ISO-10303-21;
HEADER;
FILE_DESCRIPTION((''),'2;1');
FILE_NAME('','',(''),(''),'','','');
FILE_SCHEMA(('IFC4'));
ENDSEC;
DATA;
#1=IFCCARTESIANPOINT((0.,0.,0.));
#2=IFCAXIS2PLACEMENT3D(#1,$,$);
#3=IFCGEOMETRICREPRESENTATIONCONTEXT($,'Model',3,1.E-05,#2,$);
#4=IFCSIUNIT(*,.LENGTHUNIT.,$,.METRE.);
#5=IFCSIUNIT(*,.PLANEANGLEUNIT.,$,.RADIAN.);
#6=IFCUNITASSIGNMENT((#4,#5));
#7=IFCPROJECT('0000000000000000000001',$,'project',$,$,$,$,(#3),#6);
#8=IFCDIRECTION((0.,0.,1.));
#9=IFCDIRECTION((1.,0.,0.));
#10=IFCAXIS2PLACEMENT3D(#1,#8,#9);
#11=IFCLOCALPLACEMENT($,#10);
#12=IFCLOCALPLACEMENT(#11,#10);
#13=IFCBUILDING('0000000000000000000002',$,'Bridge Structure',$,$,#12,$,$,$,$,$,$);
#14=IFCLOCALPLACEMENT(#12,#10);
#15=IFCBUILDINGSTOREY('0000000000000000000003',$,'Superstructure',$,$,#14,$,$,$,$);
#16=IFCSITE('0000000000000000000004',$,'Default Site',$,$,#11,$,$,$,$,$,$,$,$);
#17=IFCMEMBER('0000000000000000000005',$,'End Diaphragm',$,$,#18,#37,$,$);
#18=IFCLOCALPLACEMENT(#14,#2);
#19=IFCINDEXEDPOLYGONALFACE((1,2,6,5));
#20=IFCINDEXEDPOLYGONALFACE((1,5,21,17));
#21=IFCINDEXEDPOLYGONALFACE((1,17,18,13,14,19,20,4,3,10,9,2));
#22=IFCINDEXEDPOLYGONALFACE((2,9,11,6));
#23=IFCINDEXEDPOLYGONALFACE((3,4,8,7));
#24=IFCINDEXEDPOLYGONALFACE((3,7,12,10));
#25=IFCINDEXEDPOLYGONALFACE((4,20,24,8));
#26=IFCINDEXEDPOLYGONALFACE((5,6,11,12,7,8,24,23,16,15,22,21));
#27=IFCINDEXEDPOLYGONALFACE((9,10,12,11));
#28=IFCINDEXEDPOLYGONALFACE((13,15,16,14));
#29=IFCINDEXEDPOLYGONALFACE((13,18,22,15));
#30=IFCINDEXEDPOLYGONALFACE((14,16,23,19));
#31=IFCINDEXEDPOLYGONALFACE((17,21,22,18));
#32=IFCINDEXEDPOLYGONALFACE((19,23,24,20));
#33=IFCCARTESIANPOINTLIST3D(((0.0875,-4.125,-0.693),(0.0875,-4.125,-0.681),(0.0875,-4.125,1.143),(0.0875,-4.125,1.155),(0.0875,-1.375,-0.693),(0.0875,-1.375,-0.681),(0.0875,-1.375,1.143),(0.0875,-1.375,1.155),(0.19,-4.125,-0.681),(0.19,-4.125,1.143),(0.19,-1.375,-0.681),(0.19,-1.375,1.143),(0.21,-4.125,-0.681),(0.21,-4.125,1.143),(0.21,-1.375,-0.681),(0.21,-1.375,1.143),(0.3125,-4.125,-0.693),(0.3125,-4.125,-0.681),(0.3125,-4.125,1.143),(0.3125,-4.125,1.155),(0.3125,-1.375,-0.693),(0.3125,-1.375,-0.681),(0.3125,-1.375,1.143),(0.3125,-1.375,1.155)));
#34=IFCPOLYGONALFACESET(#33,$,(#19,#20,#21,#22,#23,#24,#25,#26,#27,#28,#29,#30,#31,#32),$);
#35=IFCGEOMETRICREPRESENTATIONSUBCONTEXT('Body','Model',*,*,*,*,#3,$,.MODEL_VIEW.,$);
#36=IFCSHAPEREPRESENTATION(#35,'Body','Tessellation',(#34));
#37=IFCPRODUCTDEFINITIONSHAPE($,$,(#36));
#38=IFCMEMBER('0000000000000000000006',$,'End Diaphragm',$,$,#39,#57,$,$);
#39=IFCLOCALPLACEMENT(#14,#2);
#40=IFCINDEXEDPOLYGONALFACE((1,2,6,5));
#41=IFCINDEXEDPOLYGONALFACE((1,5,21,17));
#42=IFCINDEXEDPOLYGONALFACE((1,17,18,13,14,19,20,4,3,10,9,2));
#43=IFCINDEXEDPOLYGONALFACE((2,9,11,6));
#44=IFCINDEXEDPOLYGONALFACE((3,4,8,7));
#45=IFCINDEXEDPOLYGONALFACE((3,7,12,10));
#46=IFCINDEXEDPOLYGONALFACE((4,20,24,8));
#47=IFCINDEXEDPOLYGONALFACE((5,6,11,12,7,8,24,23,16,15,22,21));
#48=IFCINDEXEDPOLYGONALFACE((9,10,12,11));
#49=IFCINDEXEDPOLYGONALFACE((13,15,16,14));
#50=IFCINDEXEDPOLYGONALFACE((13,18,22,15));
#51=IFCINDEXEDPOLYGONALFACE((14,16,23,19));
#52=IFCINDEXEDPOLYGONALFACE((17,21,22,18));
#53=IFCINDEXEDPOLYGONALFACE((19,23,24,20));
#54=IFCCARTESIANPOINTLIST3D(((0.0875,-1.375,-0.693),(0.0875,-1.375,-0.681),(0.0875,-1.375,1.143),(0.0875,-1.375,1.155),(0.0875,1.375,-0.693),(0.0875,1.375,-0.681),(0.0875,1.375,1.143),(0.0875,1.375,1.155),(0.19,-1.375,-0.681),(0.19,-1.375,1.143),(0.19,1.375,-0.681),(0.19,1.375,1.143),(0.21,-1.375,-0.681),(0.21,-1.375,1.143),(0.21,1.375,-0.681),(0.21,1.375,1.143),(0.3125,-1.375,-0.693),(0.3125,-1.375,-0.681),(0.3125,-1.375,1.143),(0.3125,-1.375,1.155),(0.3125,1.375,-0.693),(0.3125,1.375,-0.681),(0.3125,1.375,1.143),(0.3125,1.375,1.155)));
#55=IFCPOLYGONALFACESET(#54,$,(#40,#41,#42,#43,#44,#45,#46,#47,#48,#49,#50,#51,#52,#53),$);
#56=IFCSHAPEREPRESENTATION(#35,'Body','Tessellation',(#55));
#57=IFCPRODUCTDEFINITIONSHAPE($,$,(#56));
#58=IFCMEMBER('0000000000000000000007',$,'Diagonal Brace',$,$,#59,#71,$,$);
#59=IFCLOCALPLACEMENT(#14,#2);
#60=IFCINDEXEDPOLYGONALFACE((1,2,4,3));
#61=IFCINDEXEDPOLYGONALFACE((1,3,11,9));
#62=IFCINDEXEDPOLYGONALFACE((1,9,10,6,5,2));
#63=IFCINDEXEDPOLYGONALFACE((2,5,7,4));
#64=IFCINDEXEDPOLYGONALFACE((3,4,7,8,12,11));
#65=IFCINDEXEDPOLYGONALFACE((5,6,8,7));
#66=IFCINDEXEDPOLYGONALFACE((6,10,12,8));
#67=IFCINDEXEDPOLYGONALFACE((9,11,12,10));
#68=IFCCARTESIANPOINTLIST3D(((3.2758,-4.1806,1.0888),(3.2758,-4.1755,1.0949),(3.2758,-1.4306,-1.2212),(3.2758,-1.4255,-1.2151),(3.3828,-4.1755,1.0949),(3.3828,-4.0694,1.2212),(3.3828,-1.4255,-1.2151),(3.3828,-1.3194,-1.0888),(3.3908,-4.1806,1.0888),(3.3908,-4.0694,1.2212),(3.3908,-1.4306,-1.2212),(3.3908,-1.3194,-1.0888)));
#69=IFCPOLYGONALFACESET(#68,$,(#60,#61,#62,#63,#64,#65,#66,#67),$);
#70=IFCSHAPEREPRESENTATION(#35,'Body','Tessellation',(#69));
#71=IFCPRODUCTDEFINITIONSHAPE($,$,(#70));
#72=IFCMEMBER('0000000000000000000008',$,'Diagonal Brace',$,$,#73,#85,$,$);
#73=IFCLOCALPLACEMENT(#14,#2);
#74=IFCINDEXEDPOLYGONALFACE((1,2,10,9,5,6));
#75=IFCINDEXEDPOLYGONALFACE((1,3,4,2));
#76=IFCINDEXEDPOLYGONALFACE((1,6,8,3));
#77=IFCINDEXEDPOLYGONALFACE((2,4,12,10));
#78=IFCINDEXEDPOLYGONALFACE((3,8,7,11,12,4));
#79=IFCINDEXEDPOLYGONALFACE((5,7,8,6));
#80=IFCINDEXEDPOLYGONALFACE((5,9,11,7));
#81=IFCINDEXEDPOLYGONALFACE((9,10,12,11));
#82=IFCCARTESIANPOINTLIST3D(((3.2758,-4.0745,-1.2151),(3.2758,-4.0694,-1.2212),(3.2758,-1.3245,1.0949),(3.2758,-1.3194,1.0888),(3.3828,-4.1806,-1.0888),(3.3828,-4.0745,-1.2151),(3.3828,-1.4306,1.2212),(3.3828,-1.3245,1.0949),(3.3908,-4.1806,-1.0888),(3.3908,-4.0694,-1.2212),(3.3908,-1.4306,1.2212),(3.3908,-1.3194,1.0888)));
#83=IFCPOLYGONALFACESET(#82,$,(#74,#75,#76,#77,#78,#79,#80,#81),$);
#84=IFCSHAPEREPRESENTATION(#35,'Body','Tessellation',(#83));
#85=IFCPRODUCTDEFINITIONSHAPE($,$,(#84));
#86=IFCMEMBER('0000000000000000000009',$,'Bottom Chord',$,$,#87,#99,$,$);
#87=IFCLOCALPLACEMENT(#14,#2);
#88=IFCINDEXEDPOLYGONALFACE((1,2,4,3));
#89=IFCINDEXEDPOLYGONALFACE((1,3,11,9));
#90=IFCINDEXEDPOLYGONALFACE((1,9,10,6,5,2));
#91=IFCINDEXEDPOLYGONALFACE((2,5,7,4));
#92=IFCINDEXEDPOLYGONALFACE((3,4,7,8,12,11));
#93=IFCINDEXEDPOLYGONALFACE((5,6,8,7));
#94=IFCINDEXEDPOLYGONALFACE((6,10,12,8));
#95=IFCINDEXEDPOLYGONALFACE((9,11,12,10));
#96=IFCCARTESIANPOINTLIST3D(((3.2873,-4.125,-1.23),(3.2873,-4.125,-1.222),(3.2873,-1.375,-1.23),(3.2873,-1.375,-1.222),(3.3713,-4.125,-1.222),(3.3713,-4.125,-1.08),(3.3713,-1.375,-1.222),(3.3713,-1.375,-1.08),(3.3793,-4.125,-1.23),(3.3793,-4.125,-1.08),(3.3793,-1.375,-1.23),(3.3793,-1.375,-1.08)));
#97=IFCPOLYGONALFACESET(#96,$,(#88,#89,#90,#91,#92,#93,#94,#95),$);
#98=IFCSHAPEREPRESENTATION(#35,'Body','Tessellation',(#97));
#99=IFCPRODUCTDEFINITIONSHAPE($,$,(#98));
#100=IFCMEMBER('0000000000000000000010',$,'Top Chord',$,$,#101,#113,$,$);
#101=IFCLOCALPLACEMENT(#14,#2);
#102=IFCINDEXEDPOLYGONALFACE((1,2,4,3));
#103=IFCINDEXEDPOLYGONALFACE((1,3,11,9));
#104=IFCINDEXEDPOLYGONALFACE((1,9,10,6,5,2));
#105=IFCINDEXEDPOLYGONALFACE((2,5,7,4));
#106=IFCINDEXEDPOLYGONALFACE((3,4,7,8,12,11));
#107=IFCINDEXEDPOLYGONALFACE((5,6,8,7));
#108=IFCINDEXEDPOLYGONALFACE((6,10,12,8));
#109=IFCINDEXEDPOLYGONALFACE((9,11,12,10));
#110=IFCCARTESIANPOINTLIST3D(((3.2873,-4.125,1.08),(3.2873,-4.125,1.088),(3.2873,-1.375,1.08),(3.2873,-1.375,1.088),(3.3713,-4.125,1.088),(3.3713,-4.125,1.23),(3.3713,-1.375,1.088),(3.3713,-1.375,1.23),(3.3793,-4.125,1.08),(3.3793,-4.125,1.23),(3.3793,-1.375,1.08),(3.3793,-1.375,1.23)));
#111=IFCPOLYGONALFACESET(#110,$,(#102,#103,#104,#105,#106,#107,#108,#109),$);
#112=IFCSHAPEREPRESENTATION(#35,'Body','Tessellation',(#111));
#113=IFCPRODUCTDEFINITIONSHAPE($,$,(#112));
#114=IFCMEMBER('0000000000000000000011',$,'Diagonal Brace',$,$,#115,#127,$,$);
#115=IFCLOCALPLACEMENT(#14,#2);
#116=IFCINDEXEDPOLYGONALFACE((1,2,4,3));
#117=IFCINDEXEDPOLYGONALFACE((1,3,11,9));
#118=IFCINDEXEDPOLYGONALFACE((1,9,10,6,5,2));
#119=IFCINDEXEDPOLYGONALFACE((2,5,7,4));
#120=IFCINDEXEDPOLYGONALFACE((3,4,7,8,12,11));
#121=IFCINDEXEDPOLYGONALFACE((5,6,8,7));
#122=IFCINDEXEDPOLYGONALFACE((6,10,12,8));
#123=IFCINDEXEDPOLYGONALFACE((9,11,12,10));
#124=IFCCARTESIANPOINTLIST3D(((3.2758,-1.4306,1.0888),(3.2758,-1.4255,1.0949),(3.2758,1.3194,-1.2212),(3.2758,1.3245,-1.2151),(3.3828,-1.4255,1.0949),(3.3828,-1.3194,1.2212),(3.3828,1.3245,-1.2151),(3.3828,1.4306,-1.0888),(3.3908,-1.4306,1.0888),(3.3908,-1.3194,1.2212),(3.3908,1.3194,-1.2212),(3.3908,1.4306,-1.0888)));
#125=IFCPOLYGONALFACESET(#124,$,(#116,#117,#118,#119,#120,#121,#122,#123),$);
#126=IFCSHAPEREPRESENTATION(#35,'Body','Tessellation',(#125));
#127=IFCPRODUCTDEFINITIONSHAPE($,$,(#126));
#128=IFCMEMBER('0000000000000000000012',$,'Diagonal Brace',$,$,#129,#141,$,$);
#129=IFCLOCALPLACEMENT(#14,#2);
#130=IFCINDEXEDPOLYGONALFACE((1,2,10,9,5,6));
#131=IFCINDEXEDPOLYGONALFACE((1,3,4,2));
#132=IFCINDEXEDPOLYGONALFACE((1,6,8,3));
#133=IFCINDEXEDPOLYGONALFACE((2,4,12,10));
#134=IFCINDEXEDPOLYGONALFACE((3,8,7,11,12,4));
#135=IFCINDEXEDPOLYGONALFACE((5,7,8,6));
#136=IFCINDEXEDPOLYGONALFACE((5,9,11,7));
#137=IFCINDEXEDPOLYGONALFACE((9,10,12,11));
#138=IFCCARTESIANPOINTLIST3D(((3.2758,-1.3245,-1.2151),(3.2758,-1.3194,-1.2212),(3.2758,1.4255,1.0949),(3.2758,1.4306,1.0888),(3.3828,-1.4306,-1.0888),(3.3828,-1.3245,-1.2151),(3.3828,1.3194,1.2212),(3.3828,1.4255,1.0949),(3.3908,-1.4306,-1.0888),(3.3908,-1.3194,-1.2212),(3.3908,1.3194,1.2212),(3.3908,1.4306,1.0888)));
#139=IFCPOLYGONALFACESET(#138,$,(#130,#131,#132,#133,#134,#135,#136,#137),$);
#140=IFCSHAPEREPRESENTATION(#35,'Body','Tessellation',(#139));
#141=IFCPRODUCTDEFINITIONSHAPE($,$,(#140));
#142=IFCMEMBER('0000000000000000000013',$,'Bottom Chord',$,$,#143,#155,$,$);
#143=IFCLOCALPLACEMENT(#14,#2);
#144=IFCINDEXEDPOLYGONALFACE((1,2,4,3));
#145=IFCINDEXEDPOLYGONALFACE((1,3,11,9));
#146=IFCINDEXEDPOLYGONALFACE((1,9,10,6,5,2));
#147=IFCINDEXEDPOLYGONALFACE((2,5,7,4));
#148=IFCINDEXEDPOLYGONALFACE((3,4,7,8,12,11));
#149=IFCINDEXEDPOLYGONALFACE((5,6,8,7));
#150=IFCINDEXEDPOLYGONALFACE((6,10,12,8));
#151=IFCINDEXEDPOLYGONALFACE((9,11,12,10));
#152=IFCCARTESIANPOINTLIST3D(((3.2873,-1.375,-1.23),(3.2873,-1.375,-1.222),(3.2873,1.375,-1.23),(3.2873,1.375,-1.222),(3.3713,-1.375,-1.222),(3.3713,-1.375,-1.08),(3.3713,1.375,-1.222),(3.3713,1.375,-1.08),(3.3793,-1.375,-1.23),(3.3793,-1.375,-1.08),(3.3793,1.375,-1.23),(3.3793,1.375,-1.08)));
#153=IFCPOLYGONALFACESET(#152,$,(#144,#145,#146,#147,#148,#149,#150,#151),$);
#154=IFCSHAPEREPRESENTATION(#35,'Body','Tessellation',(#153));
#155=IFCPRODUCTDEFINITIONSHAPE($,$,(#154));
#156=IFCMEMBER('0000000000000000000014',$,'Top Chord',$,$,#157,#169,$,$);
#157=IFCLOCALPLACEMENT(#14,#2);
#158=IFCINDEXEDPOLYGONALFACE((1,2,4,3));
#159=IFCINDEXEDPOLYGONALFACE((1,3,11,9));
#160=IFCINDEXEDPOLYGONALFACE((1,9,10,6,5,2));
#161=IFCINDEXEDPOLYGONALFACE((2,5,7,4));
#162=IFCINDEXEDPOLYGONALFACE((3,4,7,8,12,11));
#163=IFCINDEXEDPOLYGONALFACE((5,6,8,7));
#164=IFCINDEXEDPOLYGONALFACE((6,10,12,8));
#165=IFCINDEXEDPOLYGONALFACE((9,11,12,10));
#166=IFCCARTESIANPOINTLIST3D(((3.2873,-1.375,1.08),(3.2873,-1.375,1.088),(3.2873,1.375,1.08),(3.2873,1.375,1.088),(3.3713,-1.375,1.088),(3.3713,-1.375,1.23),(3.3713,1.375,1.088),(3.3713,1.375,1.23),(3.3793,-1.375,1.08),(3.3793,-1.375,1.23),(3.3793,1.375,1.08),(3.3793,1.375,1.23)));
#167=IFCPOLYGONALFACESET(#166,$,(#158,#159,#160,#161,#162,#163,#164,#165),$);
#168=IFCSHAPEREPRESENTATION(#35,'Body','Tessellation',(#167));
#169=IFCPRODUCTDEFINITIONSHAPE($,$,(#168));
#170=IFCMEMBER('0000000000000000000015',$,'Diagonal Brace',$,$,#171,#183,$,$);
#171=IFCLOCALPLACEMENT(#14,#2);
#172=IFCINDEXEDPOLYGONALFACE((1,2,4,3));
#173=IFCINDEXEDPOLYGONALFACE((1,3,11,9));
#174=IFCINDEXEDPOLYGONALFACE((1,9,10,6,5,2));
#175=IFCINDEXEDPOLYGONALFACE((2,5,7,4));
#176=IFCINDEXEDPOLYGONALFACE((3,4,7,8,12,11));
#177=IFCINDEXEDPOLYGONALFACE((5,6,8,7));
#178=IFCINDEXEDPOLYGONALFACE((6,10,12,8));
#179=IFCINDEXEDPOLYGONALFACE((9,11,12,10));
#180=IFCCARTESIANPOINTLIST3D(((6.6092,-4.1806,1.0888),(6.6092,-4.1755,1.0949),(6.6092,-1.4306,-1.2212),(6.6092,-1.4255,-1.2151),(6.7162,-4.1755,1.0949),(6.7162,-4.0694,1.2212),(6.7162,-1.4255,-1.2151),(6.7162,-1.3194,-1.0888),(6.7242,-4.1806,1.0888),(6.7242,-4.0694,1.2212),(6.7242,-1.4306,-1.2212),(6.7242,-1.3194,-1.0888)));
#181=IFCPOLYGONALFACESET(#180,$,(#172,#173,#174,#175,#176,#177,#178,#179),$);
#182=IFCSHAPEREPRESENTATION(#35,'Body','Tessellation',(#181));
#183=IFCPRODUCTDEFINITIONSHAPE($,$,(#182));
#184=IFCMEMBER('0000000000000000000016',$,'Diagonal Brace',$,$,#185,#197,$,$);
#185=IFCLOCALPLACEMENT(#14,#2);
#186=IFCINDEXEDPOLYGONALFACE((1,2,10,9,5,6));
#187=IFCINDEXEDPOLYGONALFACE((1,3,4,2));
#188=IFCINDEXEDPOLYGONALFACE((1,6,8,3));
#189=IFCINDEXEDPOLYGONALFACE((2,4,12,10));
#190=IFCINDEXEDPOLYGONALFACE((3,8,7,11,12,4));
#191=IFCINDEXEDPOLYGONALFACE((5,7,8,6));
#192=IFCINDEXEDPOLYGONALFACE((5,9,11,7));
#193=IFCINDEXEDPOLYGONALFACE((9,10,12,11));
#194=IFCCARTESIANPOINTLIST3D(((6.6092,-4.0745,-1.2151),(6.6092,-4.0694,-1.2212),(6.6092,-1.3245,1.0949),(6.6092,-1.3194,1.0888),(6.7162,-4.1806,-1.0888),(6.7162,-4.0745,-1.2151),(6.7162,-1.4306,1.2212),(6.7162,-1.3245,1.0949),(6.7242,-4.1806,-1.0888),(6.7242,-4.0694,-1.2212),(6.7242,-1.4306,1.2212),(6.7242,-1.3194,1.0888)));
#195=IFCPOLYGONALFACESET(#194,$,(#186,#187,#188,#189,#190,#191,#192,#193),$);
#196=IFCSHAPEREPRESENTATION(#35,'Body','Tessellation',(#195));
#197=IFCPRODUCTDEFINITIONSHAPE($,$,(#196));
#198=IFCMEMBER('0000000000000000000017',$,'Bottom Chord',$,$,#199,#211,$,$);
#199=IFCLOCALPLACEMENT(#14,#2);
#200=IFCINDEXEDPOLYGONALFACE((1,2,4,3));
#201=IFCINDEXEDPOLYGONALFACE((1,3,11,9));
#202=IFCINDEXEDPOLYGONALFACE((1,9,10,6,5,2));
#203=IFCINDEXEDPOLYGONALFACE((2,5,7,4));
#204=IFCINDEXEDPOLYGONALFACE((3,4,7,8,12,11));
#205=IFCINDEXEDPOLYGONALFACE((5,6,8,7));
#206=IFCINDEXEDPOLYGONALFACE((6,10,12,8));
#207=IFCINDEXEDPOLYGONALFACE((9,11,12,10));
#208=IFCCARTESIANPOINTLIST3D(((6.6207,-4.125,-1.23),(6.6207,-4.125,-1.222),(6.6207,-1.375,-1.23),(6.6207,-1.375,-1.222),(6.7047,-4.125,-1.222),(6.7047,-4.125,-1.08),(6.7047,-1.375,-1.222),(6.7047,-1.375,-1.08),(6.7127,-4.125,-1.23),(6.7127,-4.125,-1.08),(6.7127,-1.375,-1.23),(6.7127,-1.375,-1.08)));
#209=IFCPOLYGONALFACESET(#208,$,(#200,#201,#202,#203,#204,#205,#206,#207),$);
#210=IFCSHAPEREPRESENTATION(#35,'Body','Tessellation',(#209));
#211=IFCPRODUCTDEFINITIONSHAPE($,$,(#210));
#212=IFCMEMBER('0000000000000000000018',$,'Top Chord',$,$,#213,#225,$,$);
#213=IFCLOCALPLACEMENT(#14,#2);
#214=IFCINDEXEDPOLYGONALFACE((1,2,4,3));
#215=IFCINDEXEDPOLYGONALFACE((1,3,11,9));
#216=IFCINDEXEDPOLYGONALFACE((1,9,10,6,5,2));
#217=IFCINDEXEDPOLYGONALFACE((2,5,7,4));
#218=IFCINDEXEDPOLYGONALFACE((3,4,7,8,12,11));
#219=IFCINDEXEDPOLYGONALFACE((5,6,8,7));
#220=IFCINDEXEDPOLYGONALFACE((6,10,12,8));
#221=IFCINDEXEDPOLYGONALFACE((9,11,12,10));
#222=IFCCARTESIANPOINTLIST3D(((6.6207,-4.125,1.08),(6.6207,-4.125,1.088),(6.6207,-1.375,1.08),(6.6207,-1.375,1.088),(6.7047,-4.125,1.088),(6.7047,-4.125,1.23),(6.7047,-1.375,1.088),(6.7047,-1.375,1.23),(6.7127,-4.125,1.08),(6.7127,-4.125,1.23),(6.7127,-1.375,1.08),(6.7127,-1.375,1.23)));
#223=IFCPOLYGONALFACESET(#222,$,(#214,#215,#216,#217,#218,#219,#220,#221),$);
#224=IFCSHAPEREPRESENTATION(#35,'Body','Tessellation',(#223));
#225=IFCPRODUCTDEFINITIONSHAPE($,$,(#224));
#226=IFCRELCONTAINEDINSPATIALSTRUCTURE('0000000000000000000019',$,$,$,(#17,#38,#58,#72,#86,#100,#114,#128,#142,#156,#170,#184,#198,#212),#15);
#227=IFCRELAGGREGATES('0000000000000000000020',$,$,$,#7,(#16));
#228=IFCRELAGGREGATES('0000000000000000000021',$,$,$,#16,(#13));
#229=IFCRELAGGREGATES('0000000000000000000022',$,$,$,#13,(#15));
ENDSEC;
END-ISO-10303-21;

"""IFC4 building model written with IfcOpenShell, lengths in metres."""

from ifc_helpers import new_model, si_unit, frame, origin, origin_with_axes, origin_2d_with_axis, place, context, subcontext, project, spatial, i_section, l_section, extrude, element, save


model = new_model("IFC4")

# Units and contexts
model_context = context("Model", 3, precision=1e-05, world=origin())
body_context = subcontext(model_context, "Body", "Model", "MODEL_VIEW")
ifc_project = project(units=[si_unit("LENGTHUNIT", "METRE"), si_unit("PLANEANGLEUNIT", "RADIAN")], contexts=[model_context])

# Site, building, storey
site_placement = place(None, origin_with_axes())
site = spatial("IfcSite", under=ifc_project, at=site_placement, Name="Default Site")
building_placement = place(site_placement, origin_with_axes())
building = spatial("IfcBuilding", under=site, at=building_placement, Name="Bridge Structure")
storey_placement = place(building_placement, origin_with_axes())
storey = spatial("IfcBuildingStorey", under=building, at=storey_placement, Name="Superstructure")

# Members
for number, where, z_axis, x_axis, name in (
    (1, (0.2, -4.125, 0.231), (0.0, 1.0, 0.0), (-1.0, 0.0, 0.0), "End Diaphragm"),
    (2, (0.2, -1.375, 0.231), (0.0, 1.0, 0.0), (-1.0, 0.0, 0.0), "End Diaphragm"),
):
    element("IfcMember", number, at=place(storey_placement, frame(where, z_axis=z_axis, x_axis=x_axis)), inside=storey, Name=name, context=body_context, shape_type="SweptSolid", body=[
        extrude(i_section(OverallWidth=0.225, OverallDepth=1.848, WebThickness=0.02, FlangeThickness=0.012, at=origin_2d_with_axis()), origin_with_axes(), (0.0, 0.0, 1.0), 2.75),
    ])
for number, where, z_axis, x_axis, name in (
    (3, (3.3333, -4.125, 1.155), (0.0, 0.765705, -0.643192), (-1.0, 0.0, 0.0), "Diagonal Brace"),
    (4, (3.3333, -4.125, -1.155), (0.0, 0.765705, 0.643192), (-1.0, 0.0, 0.0), "Diagonal Brace"),
):
    element("IfcMember", number, at=place(storey_placement, frame(where, z_axis=z_axis, x_axis=x_axis)), inside=storey, Name=name, context=body_context, shape_type="SweptSolid", body=[
        extrude(l_section(Depth=0.173, Width=0.115, Thickness=0.008, at=origin_2d_with_axis()), origin_with_axes(), (0.0, 0.0, 1.0), 3.5915),
    ])
for number, where, z_axis, x_axis, name in (
    (5, (3.3333, -4.125, -1.155), (0.0, 1.0, 0.0), (-1.0, 0.0, 0.0), "Bottom Chord"),
    (6, (3.3333, -4.125, 1.155), (0.0, 1.0, 0.0), (-1.0, 0.0, 0.0), "Top Chord"),
):
    element("IfcMember", number, at=place(storey_placement, frame(where, z_axis=z_axis, x_axis=x_axis)), inside=storey, Name=name, context=body_context, shape_type="SweptSolid", body=[
        extrude(l_section(Depth=0.15, Width=0.092, Thickness=0.008, at=origin_2d_with_axis()), origin_with_axes(), (0.0, 0.0, 1.0), 2.75),
    ])
for number, where, z_axis, x_axis, name in (
    (7, (3.3333, -1.375, 1.155), (0.0, 0.765705, -0.643192), (-1.0, 0.0, 0.0), "Diagonal Brace"),
    (8, (3.3333, -1.375, -1.155), (0.0, 0.765705, 0.643192), (-1.0, 0.0, 0.0), "Diagonal Brace"),
):
    element("IfcMember", number, at=place(storey_placement, frame(where, z_axis=z_axis, x_axis=x_axis)), inside=storey, Name=name, context=body_context, shape_type="SweptSolid", body=[
        extrude(l_section(Depth=0.173, Width=0.115, Thickness=0.008, at=origin_2d_with_axis()), origin_with_axes(), (0.0, 0.0, 1.0), 3.5915),
    ])
for number, where, z_axis, x_axis, name in (
    (9, (3.3333, -1.375, -1.155), (0.0, 1.0, 0.0), (-1.0, 0.0, 0.0), "Bottom Chord"),
    (10, (3.3333, -1.375, 1.155), (0.0, 1.0, 0.0), (-1.0, 0.0, 0.0), "Top Chord"),
):
    element("IfcMember", number, at=place(storey_placement, frame(where, z_axis=z_axis, x_axis=x_axis)), inside=storey, Name=name, context=body_context, shape_type="SweptSolid", body=[
        extrude(l_section(Depth=0.15, Width=0.092, Thickness=0.008, at=origin_2d_with_axis()), origin_with_axes(), (0.0, 0.0, 1.0), 2.75),
    ])
for number, where, z_axis, x_axis, name in (
    (11, (6.6667, -4.125, 1.155), (0.0, 0.765705, -0.643192), (-1.0, 0.0, 0.0), "Diagonal Brace"),
    (12, (6.6667, -4.125, -1.155), (0.0, 0.765705, 0.643192), (-1.0, 0.0, 0.0), "Diagonal Brace"),
):
    element("IfcMember", number, at=place(storey_placement, frame(where, z_axis=z_axis, x_axis=x_axis)), inside=storey, Name=name, context=body_context, shape_type="SweptSolid", body=[
        extrude(l_section(Depth=0.173, Width=0.115, Thickness=0.008, at=origin_2d_with_axis()), origin_with_axes(), (0.0, 0.0, 1.0), 3.5915),
    ])
for number, where, z_axis, x_axis, name in (
    (13, (6.6667, -4.125, -1.155), (0.0, 1.0, 0.0), (-1.0, 0.0, 0.0), "Bottom Chord"),
    (14, (6.6667, -4.125, 1.155), (0.0, 1.0, 0.0), (-1.0, 0.0, 0.0), "Top Chord"),
):
    element("IfcMember", number, at=place(storey_placement, frame(where, z_axis=z_axis, x_axis=x_axis)), inside=storey, Name=name, context=body_context, shape_type="SweptSolid", body=[
        extrude(l_section(Depth=0.15, Width=0.092, Thickness=0.008, at=origin_2d_with_axis()), origin_with_axes(), (0.0, 0.0, 1.0), 2.75),
    ])

save(model, "model.ifc")
